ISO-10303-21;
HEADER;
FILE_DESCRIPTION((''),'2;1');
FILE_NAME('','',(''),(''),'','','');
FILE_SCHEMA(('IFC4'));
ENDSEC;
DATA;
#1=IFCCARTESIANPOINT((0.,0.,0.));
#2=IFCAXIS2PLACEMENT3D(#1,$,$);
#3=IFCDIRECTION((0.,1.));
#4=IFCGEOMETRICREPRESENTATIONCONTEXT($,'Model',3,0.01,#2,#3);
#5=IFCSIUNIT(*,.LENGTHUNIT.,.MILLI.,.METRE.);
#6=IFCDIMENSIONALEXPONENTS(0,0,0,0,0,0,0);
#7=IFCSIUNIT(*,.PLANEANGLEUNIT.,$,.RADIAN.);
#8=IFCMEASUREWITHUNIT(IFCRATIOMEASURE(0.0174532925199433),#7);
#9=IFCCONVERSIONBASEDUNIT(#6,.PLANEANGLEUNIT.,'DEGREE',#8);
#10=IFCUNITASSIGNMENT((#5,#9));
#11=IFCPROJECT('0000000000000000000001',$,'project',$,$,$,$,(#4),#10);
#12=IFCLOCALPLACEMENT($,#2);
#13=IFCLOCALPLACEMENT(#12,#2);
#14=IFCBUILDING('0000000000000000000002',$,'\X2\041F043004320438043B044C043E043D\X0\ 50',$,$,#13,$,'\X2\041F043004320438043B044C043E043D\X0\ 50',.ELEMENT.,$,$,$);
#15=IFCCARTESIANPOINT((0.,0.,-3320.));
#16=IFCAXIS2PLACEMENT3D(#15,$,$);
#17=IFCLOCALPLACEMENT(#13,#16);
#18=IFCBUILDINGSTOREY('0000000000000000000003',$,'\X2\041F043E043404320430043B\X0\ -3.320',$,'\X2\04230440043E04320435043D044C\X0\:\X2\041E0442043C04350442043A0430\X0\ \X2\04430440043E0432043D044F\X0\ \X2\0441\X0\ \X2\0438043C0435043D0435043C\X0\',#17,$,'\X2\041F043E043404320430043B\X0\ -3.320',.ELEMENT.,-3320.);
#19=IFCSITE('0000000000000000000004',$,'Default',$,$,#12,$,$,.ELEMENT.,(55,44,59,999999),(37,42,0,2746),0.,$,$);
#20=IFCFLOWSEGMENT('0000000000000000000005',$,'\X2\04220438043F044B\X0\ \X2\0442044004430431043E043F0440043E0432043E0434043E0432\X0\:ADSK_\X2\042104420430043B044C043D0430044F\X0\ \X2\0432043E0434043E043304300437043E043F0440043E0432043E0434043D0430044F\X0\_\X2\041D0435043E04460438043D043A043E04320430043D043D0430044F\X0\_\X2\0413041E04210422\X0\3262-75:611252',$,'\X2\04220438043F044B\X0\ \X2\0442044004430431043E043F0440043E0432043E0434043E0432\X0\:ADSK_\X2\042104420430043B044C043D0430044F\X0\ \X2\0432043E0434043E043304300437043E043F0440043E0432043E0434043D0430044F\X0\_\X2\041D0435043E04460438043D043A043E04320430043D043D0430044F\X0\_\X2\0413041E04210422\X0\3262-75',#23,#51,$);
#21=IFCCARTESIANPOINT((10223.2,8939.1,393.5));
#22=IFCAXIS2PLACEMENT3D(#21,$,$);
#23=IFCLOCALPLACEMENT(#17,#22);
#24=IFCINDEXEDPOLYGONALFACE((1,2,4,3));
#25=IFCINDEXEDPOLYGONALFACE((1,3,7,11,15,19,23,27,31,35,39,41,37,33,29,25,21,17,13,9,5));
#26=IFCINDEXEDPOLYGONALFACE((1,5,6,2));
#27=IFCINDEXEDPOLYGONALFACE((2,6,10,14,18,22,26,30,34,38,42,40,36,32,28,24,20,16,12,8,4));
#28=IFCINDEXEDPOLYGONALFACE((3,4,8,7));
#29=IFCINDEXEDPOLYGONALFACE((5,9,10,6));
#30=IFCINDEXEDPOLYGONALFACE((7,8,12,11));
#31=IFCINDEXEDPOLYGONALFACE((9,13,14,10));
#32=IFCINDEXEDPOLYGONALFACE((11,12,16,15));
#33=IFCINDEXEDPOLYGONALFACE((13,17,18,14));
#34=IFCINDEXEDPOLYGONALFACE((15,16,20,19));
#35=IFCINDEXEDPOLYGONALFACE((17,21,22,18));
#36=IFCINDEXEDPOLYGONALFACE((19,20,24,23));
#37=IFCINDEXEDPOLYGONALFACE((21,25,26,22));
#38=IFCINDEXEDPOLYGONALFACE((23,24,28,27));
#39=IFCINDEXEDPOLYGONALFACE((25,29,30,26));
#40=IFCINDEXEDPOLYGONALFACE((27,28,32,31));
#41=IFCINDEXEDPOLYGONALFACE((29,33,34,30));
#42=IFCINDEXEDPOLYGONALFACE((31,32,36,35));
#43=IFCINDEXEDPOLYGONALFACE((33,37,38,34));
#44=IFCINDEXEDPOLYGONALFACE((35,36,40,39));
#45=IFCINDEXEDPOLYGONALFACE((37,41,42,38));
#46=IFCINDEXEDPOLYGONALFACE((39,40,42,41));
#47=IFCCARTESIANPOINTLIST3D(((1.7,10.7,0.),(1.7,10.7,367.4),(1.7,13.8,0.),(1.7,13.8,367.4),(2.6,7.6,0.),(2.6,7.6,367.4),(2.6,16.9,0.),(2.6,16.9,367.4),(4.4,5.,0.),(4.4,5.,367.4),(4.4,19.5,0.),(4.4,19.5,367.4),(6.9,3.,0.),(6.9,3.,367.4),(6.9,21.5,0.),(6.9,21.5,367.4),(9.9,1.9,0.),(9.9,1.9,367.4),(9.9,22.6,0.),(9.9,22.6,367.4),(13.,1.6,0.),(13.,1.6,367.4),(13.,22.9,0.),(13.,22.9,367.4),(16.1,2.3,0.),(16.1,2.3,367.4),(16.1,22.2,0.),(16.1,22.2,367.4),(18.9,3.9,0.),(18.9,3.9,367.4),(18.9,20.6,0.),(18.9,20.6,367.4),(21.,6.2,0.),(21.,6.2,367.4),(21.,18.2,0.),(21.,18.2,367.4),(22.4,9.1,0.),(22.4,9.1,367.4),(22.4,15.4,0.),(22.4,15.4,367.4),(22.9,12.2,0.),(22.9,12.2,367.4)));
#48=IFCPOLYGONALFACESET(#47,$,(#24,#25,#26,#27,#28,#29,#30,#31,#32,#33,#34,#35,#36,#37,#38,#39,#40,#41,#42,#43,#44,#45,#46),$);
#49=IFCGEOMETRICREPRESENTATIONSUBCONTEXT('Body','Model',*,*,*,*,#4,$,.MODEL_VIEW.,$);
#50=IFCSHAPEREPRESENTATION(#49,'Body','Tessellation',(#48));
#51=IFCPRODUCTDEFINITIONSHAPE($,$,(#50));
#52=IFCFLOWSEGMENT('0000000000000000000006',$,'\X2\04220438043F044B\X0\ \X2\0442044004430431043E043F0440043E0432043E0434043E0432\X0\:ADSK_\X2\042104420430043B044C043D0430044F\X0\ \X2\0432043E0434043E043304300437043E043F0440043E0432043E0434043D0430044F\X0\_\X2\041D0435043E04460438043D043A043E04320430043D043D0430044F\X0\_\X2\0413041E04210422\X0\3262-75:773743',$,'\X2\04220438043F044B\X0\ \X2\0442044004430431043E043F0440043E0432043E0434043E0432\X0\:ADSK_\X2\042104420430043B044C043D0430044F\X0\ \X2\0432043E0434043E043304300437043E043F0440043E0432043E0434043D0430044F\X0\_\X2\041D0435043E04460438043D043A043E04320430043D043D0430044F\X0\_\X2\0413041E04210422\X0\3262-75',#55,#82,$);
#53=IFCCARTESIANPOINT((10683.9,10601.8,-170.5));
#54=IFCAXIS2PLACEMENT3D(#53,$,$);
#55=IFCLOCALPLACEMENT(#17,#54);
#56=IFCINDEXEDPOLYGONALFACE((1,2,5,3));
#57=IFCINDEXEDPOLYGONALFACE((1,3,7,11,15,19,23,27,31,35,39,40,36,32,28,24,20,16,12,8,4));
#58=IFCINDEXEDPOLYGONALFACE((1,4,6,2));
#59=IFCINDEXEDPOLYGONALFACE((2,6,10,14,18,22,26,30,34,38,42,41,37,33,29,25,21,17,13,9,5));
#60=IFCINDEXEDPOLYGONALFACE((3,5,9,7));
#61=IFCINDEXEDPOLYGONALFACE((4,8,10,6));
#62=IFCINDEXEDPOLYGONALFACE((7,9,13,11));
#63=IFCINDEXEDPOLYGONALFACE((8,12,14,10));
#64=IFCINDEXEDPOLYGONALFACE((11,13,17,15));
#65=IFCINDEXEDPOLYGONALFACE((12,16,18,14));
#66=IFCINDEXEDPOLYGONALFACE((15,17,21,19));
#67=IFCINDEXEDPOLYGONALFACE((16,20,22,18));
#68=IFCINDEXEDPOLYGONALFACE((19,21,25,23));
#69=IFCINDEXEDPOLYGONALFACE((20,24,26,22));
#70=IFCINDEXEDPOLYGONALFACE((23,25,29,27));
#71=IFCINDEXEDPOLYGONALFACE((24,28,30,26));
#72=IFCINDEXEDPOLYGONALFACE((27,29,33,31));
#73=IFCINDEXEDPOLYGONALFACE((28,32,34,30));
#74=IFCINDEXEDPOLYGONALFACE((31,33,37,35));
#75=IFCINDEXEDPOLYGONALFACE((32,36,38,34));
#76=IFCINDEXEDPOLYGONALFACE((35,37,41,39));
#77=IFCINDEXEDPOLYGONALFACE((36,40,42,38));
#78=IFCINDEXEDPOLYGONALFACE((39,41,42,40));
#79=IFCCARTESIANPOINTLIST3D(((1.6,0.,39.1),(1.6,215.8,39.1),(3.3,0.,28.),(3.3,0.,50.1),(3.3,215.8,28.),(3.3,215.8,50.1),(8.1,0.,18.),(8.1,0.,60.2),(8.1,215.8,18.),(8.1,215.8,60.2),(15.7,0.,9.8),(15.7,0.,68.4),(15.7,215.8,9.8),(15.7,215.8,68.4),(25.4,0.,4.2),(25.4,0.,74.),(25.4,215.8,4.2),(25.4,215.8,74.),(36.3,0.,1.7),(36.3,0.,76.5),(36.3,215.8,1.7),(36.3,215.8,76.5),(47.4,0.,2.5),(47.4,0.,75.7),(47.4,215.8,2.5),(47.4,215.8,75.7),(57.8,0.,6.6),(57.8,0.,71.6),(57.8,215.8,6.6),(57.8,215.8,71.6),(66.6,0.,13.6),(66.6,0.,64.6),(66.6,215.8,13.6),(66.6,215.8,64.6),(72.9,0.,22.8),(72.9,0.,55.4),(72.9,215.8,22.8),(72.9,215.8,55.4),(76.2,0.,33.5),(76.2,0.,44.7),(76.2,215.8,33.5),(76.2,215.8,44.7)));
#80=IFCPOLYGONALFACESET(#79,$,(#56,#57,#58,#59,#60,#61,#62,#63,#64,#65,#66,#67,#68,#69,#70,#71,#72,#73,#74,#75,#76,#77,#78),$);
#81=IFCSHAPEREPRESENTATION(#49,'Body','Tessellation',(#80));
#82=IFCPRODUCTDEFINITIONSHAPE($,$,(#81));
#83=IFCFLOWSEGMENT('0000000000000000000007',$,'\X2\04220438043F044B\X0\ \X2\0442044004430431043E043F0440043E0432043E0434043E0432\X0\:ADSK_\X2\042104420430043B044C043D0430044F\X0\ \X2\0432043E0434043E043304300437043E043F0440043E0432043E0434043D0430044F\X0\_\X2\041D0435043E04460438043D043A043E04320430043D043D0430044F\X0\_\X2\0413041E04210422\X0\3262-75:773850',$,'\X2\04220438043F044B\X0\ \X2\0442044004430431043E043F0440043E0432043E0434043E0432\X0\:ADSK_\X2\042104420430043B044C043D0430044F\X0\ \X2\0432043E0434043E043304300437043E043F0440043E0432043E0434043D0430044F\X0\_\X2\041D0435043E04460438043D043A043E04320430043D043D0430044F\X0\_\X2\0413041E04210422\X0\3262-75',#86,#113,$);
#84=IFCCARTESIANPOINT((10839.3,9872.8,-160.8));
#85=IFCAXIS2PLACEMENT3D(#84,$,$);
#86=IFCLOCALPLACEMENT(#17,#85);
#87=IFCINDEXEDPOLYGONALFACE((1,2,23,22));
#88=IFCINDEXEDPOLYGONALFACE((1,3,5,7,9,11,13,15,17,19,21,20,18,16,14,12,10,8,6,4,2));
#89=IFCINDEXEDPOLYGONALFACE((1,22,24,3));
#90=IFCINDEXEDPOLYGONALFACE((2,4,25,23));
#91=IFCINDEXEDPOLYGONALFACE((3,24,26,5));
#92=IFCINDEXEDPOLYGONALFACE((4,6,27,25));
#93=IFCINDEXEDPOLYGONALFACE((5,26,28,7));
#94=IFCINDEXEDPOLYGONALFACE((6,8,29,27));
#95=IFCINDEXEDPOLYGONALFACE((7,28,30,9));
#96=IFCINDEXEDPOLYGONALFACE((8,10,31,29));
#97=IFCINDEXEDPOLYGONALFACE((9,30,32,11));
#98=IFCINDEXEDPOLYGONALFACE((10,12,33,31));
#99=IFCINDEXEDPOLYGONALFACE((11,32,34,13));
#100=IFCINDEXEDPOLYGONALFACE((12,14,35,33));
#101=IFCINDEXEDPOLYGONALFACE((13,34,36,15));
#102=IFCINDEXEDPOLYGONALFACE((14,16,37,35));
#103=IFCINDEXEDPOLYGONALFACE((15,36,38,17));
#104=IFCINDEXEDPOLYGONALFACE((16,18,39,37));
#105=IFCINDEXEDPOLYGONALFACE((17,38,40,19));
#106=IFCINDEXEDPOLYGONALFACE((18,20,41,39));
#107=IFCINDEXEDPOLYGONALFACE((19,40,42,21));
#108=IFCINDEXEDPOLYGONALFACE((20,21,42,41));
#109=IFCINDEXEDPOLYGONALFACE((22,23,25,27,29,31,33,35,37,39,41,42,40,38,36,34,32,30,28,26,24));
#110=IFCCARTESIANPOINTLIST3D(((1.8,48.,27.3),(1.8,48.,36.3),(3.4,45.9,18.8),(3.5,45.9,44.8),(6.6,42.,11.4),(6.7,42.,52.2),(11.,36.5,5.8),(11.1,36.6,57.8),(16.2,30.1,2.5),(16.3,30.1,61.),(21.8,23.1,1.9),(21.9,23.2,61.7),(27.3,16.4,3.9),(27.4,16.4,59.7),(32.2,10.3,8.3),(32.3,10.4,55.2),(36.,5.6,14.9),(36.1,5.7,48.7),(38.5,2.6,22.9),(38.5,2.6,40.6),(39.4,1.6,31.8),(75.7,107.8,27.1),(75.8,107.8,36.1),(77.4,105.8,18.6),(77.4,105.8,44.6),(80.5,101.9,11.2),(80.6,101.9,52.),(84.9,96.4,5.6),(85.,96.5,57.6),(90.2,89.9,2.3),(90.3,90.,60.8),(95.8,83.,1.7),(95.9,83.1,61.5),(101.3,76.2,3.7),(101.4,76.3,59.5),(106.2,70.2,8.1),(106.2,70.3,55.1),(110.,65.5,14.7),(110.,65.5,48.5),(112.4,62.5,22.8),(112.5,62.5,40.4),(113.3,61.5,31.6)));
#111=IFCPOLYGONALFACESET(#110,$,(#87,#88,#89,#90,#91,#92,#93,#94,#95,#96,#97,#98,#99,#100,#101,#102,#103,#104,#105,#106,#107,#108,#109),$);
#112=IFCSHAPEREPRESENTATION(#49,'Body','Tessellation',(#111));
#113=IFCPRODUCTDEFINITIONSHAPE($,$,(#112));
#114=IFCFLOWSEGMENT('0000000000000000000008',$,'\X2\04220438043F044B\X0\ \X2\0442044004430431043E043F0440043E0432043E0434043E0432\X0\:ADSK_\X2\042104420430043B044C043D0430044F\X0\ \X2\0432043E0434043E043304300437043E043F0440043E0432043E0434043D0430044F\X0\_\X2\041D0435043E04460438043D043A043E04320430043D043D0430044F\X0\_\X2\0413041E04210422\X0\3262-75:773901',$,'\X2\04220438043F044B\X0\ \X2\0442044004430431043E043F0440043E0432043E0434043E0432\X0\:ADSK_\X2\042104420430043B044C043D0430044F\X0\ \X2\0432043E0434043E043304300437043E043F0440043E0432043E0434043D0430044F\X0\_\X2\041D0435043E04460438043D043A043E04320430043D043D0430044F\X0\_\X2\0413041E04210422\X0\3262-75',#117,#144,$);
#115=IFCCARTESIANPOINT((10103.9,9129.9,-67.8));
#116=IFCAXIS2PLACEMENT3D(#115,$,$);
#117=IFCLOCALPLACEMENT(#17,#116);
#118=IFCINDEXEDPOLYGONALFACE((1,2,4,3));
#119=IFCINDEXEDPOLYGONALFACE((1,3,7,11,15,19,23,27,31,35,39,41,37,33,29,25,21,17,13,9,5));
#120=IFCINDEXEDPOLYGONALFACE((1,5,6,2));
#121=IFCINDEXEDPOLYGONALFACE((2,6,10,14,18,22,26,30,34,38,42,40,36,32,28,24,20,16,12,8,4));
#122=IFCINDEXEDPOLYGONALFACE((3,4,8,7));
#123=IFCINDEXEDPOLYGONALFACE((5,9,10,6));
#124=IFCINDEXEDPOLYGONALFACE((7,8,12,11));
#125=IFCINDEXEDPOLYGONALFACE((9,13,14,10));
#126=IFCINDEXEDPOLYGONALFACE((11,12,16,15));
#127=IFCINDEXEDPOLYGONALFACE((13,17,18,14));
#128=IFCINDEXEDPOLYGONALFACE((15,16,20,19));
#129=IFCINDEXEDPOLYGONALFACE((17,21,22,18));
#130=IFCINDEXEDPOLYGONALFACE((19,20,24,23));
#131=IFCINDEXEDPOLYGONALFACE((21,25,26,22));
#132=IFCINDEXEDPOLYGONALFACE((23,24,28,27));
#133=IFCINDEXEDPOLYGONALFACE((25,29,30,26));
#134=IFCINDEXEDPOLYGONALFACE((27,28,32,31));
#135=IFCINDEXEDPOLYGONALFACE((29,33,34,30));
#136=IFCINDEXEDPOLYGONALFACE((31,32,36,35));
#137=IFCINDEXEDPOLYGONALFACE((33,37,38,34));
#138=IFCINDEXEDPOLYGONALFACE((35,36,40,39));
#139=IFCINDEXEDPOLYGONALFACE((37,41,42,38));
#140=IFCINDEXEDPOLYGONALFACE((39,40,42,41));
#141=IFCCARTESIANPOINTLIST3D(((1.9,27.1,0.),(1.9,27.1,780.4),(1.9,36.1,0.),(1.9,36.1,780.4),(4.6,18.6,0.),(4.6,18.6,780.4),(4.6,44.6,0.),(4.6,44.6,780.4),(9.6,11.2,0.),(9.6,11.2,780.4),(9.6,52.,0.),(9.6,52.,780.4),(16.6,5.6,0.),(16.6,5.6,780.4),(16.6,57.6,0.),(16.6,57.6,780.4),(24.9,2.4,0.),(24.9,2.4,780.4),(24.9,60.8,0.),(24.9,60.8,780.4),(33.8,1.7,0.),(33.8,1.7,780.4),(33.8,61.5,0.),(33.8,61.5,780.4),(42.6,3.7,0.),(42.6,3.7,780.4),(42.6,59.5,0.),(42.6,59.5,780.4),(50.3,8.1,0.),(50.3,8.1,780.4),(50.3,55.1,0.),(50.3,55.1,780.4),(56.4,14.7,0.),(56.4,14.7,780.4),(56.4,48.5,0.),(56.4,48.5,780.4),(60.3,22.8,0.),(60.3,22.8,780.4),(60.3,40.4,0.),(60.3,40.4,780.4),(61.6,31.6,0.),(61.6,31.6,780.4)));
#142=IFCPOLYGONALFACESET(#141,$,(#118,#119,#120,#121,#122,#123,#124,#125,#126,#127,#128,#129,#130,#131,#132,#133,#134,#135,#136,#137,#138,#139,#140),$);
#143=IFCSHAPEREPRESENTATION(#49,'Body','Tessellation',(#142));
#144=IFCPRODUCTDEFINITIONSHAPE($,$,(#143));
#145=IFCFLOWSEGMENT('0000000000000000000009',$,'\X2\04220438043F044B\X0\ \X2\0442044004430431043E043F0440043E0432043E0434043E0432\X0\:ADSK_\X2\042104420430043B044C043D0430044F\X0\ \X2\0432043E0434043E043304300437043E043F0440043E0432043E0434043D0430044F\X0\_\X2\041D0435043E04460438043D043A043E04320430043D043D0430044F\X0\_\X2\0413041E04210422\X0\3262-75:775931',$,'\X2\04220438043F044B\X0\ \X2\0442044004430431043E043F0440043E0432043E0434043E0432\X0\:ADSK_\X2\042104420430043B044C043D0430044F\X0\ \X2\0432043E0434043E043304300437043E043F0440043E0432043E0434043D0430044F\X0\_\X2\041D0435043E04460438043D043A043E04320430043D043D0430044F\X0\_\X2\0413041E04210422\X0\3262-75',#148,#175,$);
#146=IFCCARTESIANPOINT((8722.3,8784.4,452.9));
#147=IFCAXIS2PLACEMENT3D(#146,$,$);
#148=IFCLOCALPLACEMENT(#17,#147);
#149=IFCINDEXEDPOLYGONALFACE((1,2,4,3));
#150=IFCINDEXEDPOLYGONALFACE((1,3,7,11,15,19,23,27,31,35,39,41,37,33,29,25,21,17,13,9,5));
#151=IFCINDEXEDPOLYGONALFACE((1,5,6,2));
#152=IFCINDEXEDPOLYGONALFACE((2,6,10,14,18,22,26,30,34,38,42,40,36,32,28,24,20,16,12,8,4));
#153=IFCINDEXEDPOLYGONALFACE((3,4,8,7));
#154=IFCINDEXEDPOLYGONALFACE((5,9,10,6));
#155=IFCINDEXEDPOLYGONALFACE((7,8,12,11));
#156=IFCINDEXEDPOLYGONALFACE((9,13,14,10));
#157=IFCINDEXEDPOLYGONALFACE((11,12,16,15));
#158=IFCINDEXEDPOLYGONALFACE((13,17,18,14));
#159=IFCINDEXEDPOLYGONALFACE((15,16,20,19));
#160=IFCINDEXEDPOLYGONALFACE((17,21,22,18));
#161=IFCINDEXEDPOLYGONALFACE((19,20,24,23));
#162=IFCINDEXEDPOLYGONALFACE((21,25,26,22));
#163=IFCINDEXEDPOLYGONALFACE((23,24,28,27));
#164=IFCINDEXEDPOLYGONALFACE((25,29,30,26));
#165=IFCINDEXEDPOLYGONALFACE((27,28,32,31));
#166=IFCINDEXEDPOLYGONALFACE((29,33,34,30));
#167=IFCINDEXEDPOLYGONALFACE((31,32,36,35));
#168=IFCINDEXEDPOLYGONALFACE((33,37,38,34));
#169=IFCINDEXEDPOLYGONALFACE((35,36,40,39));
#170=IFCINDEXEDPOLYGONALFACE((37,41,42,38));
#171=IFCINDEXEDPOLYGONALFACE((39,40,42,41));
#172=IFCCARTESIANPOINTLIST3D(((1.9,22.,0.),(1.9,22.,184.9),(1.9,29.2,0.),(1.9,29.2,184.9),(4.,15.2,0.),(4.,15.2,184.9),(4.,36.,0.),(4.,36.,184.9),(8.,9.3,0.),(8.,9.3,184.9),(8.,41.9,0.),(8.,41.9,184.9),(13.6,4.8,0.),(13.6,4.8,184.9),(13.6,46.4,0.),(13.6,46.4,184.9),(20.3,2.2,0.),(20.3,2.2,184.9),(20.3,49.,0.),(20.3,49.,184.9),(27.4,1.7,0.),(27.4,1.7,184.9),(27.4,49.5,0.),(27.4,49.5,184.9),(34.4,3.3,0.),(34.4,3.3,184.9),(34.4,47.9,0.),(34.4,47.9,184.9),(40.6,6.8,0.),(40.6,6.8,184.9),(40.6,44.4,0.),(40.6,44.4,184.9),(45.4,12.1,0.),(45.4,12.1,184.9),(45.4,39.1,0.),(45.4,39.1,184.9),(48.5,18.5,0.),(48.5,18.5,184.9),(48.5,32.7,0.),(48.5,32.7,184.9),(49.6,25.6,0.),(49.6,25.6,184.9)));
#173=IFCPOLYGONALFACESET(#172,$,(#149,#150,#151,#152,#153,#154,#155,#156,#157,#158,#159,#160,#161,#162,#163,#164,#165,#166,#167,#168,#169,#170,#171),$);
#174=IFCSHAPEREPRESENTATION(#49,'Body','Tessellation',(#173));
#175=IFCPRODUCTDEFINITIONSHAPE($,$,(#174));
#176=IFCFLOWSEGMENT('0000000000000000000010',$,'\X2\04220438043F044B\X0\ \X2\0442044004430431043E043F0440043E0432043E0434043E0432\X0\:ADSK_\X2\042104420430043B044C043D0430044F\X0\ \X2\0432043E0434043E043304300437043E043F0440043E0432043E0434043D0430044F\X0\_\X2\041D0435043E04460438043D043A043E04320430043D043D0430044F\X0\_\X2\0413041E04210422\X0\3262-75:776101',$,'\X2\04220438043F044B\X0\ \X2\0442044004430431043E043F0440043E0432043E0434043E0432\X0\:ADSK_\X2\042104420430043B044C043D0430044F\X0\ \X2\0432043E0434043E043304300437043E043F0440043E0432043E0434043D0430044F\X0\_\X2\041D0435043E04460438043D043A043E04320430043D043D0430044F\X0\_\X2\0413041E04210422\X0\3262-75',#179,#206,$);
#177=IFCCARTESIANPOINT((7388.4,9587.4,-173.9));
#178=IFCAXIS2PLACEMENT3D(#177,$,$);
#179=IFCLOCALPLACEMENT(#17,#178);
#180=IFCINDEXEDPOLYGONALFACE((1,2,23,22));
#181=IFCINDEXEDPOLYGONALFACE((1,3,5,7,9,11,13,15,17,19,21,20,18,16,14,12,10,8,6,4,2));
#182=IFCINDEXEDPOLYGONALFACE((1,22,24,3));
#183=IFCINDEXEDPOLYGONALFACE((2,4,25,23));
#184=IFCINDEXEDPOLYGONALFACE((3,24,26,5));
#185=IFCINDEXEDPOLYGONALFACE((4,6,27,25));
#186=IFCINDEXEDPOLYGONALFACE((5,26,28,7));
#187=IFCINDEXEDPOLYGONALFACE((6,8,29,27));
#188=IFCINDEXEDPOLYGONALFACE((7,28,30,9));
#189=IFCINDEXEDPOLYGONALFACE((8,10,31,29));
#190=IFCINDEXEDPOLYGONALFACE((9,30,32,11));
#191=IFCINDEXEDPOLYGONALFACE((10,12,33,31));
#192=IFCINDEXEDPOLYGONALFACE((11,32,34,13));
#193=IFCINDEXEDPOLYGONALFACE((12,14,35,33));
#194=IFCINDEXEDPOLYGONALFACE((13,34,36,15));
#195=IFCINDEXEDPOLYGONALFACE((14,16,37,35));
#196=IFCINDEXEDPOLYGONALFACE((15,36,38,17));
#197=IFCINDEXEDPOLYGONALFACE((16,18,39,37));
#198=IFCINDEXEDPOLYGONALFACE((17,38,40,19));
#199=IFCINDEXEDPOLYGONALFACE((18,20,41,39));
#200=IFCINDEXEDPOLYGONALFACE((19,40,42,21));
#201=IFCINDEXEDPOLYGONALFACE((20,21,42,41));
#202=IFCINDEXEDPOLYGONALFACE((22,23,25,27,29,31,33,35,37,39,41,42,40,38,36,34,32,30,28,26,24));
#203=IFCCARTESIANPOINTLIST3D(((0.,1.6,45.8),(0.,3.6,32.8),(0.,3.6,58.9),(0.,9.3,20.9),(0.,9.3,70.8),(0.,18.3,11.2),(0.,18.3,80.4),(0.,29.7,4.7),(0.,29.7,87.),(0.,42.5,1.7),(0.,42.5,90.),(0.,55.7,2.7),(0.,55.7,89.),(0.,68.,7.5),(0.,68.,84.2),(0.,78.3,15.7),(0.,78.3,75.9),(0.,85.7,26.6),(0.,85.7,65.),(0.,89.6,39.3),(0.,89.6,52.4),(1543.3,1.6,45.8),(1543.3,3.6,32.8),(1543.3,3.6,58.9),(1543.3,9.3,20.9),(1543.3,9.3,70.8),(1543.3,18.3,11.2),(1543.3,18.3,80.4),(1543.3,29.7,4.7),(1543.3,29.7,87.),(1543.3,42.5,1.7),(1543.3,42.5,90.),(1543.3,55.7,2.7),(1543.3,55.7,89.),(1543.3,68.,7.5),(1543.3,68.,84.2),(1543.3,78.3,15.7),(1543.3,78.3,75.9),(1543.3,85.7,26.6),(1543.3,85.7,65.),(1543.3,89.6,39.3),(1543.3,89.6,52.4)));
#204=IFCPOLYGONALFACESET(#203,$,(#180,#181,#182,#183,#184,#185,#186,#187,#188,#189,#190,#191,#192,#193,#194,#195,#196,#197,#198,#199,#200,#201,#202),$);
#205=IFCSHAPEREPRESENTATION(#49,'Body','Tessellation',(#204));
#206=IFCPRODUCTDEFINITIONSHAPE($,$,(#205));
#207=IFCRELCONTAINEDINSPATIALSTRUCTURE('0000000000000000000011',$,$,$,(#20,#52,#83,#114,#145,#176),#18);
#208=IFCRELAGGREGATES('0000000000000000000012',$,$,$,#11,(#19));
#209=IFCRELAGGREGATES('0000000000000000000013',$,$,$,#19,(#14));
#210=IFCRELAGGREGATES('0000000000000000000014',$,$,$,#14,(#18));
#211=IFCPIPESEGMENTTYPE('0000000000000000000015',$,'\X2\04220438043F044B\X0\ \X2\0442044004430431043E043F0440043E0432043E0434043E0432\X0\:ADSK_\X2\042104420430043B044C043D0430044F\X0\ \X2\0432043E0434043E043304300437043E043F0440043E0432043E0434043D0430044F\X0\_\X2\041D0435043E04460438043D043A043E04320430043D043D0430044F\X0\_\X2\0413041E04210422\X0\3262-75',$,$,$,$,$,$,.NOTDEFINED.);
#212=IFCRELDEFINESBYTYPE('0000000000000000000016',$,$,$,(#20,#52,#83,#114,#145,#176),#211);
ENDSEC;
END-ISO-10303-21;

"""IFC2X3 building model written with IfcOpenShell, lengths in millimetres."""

from ifc_helpers import new_model, entity, si_unit, converted_unit, direction, frame, frame_2d, origin, origin_2d_with_axis, place, context, subcontext, project, spatial, circle, extrude, type_object, element, save


model = new_model("IFC2X3")

# Units and contexts
model_context = context("Model", 3, precision=0.01, world=origin(), true_north=direction((0.0, 1.0)))
body_context = subcontext(model_context, "Body", "Model", "MODEL_VIEW")
ifc_project = project(units=[si_unit("LENGTHUNIT", "METRE", prefix="MILLI"), converted_unit("PLANEANGLEUNIT", "DEGREE", entity("IfcRatioMeasure", 0.0174532925199433), si_unit("PLANEANGLEUNIT", "RADIAN"), dimensions=[0, 0, 0, 0, 0, 0, 0])], contexts=[model_context])

# Site, building, storey
site_placement = place(None, origin())
site = spatial("IfcSite", under=ifc_project, at=site_placement, Name="Default", CompositionType="ELEMENT", RefLatitude=(55, 44, 59, 999999), RefLongitude=(37, 42, 0, 2746), RefElevation=0.0)
building_placement = place(site_placement, origin())
building = spatial("IfcBuilding", under=site, at=building_placement, Name="Павильон 50", LongName="Павильон 50", CompositionType="ELEMENT")
storey_placement = place(building_placement, frame((0.0, 0.0, -3320.0)))
storey = spatial("IfcBuildingStorey", under=building, at=storey_placement, Name="Подвал -3.320", ObjectType="Уровень:Отметка уровня с именем", LongName="Подвал -3.320", CompositionType="ELEMENT", Elevation=-3320.0)

# Flow segments
pipe_segment_type = type_object("IfcPipeSegmentType", Name="Типы трубопроводов:ADSK_Стальная водогазопроводная_Неоцинкованная_ГОСТ3262-75", PredefinedType="NOTDEFINED")
flow_segment_1_placement = place(storey_placement, frame((10223.2, 8939.1, 393.5)))
element("IfcFlowSegment", 1, at=flow_segment_1_placement, inside=storey, type_object=pipe_segment_type, Name="Типы трубопроводов:ADSK_Стальная водогазопроводная_Неоцинкованная_ГОСТ3262-75:611252", ObjectType="Типы трубопроводов:ADSK_Стальная водогазопроводная_Неоцинкованная_ГОСТ3262-75", context=body_context, shape_type="SweptSolid", body=[
    extrude(circle(Radius=10.7, at=origin_2d_with_axis()), frame((12.2, 12.2, 0.0)), (0.0, 0.0, 1.0), 367.4),
])
flow_segment_2_placement = place(storey_placement, frame((10683.9, 10601.8, -170.5)))
element("IfcFlowSegment", 2, at=flow_segment_2_placement, inside=storey, type_object=pipe_segment_type, Name="Типы трубопроводов:ADSK_Стальная водогазопроводная_Неоцинкованная_ГОСТ3262-75:773743", ObjectType="Типы трубопроводов:ADSK_Стальная водогазопроводная_Неоцинкованная_ГОСТ3262-75", context=body_context, shape_type="SweptSolid", body=[
    extrude(circle(Radius=37.5, at=origin_2d_with_axis()), frame((39.1, 0.0, 39.1), z_axis=(0.0, 1.0, 0.0), x_axis=(-1.0, 0.0, 0.0)), (0.0, 0.0, 1.0), 215.8),
])
flow_segment_3_placement = place(storey_placement, frame((10839.3, 9872.8, -160.8)))
element("IfcFlowSegment", 3, at=flow_segment_3_placement, inside=storey, type_object=pipe_segment_type, Name="Типы трубопроводов:ADSK_Стальная водогазопроводная_Неоцинкованная_ГОСТ3262-75:773850", ObjectType="Типы трубопроводов:ADSK_Стальная водогазопроводная_Неоцинкованная_ГОСТ3262-75", context=body_context, shape_type="SweptSolid", body=[
    extrude(circle(Radius=30.0, at=origin_2d_with_axis()), frame((94.4, 84.8, 31.6), z_axis=(-0.777144, -0.629319, 0.002), x_axis=(0.62932, -0.777146, 0.0)), (0.0, 0.0, 1.0), 95.1),
])
flow_segment_4_placement = place(storey_placement, frame((10103.9, 9129.9, -67.8)))
element("IfcFlowSegment", 4, at=flow_segment_4_placement, inside=storey, type_object=pipe_segment_type, Name="Типы трубопроводов:ADSK_Стальная водогазопроводная_Неоцинкованная_ГОСТ3262-75:773901", ObjectType="Типы трубопроводов:ADSK_Стальная водогазопроводная_Неоцинкованная_ГОСТ3262-75", context=body_context, shape_type="SweptSolid", body=[
    extrude(circle(Radius=30.0, at=origin_2d_with_axis()), frame((31.6, 31.6, 0.0)), (0.0, 0.0, 1.0), 780.4),
])
flow_segment_5_placement = place(storey_placement, frame((8722.3, 8784.4, 452.9)))
element("IfcFlowSegment", 5, at=flow_segment_5_placement, inside=storey, type_object=pipe_segment_type, Name="Типы трубопроводов:ADSK_Стальная водогазопроводная_Неоцинкованная_ГОСТ3262-75:775931", ObjectType="Типы трубопроводов:ADSK_Стальная водогазопроводная_Неоцинкованная_ГОСТ3262-75", context=body_context, shape_type="SweptSolid", body=[
    extrude(circle(Radius=24.0, at=frame_2d((0.0, 0.0), x_axis=(1.0, 0.0))), frame((25.6, 25.6, 0.0)), (0.0, 0.0, 1.0), 184.9),
])
flow_segment_6_placement = place(storey_placement, frame((7388.4, 9587.4, -173.9)))
element("IfcFlowSegment", 6, at=flow_segment_6_placement, inside=storey, type_object=pipe_segment_type, Name="Типы трубопроводов:ADSK_Стальная водогазопроводная_Неоцинкованная_ГОСТ3262-75:776101", ObjectType="Типы трубопроводов:ADSK_Стальная водогазопроводная_Неоцинкованная_ГОСТ3262-75", context=body_context, shape_type="SweptSolid", body=[
    extrude(circle(Radius=44.2, at=origin_2d_with_axis()), frame((0.0, 45.8, 45.8), z_axis=(1.0, 0.0, 0.0), x_axis=(0.0, -1.0, 0.0)), (0.0, 0.0, 1.0), 1543.3),
])

save(model, "model.ifc")
